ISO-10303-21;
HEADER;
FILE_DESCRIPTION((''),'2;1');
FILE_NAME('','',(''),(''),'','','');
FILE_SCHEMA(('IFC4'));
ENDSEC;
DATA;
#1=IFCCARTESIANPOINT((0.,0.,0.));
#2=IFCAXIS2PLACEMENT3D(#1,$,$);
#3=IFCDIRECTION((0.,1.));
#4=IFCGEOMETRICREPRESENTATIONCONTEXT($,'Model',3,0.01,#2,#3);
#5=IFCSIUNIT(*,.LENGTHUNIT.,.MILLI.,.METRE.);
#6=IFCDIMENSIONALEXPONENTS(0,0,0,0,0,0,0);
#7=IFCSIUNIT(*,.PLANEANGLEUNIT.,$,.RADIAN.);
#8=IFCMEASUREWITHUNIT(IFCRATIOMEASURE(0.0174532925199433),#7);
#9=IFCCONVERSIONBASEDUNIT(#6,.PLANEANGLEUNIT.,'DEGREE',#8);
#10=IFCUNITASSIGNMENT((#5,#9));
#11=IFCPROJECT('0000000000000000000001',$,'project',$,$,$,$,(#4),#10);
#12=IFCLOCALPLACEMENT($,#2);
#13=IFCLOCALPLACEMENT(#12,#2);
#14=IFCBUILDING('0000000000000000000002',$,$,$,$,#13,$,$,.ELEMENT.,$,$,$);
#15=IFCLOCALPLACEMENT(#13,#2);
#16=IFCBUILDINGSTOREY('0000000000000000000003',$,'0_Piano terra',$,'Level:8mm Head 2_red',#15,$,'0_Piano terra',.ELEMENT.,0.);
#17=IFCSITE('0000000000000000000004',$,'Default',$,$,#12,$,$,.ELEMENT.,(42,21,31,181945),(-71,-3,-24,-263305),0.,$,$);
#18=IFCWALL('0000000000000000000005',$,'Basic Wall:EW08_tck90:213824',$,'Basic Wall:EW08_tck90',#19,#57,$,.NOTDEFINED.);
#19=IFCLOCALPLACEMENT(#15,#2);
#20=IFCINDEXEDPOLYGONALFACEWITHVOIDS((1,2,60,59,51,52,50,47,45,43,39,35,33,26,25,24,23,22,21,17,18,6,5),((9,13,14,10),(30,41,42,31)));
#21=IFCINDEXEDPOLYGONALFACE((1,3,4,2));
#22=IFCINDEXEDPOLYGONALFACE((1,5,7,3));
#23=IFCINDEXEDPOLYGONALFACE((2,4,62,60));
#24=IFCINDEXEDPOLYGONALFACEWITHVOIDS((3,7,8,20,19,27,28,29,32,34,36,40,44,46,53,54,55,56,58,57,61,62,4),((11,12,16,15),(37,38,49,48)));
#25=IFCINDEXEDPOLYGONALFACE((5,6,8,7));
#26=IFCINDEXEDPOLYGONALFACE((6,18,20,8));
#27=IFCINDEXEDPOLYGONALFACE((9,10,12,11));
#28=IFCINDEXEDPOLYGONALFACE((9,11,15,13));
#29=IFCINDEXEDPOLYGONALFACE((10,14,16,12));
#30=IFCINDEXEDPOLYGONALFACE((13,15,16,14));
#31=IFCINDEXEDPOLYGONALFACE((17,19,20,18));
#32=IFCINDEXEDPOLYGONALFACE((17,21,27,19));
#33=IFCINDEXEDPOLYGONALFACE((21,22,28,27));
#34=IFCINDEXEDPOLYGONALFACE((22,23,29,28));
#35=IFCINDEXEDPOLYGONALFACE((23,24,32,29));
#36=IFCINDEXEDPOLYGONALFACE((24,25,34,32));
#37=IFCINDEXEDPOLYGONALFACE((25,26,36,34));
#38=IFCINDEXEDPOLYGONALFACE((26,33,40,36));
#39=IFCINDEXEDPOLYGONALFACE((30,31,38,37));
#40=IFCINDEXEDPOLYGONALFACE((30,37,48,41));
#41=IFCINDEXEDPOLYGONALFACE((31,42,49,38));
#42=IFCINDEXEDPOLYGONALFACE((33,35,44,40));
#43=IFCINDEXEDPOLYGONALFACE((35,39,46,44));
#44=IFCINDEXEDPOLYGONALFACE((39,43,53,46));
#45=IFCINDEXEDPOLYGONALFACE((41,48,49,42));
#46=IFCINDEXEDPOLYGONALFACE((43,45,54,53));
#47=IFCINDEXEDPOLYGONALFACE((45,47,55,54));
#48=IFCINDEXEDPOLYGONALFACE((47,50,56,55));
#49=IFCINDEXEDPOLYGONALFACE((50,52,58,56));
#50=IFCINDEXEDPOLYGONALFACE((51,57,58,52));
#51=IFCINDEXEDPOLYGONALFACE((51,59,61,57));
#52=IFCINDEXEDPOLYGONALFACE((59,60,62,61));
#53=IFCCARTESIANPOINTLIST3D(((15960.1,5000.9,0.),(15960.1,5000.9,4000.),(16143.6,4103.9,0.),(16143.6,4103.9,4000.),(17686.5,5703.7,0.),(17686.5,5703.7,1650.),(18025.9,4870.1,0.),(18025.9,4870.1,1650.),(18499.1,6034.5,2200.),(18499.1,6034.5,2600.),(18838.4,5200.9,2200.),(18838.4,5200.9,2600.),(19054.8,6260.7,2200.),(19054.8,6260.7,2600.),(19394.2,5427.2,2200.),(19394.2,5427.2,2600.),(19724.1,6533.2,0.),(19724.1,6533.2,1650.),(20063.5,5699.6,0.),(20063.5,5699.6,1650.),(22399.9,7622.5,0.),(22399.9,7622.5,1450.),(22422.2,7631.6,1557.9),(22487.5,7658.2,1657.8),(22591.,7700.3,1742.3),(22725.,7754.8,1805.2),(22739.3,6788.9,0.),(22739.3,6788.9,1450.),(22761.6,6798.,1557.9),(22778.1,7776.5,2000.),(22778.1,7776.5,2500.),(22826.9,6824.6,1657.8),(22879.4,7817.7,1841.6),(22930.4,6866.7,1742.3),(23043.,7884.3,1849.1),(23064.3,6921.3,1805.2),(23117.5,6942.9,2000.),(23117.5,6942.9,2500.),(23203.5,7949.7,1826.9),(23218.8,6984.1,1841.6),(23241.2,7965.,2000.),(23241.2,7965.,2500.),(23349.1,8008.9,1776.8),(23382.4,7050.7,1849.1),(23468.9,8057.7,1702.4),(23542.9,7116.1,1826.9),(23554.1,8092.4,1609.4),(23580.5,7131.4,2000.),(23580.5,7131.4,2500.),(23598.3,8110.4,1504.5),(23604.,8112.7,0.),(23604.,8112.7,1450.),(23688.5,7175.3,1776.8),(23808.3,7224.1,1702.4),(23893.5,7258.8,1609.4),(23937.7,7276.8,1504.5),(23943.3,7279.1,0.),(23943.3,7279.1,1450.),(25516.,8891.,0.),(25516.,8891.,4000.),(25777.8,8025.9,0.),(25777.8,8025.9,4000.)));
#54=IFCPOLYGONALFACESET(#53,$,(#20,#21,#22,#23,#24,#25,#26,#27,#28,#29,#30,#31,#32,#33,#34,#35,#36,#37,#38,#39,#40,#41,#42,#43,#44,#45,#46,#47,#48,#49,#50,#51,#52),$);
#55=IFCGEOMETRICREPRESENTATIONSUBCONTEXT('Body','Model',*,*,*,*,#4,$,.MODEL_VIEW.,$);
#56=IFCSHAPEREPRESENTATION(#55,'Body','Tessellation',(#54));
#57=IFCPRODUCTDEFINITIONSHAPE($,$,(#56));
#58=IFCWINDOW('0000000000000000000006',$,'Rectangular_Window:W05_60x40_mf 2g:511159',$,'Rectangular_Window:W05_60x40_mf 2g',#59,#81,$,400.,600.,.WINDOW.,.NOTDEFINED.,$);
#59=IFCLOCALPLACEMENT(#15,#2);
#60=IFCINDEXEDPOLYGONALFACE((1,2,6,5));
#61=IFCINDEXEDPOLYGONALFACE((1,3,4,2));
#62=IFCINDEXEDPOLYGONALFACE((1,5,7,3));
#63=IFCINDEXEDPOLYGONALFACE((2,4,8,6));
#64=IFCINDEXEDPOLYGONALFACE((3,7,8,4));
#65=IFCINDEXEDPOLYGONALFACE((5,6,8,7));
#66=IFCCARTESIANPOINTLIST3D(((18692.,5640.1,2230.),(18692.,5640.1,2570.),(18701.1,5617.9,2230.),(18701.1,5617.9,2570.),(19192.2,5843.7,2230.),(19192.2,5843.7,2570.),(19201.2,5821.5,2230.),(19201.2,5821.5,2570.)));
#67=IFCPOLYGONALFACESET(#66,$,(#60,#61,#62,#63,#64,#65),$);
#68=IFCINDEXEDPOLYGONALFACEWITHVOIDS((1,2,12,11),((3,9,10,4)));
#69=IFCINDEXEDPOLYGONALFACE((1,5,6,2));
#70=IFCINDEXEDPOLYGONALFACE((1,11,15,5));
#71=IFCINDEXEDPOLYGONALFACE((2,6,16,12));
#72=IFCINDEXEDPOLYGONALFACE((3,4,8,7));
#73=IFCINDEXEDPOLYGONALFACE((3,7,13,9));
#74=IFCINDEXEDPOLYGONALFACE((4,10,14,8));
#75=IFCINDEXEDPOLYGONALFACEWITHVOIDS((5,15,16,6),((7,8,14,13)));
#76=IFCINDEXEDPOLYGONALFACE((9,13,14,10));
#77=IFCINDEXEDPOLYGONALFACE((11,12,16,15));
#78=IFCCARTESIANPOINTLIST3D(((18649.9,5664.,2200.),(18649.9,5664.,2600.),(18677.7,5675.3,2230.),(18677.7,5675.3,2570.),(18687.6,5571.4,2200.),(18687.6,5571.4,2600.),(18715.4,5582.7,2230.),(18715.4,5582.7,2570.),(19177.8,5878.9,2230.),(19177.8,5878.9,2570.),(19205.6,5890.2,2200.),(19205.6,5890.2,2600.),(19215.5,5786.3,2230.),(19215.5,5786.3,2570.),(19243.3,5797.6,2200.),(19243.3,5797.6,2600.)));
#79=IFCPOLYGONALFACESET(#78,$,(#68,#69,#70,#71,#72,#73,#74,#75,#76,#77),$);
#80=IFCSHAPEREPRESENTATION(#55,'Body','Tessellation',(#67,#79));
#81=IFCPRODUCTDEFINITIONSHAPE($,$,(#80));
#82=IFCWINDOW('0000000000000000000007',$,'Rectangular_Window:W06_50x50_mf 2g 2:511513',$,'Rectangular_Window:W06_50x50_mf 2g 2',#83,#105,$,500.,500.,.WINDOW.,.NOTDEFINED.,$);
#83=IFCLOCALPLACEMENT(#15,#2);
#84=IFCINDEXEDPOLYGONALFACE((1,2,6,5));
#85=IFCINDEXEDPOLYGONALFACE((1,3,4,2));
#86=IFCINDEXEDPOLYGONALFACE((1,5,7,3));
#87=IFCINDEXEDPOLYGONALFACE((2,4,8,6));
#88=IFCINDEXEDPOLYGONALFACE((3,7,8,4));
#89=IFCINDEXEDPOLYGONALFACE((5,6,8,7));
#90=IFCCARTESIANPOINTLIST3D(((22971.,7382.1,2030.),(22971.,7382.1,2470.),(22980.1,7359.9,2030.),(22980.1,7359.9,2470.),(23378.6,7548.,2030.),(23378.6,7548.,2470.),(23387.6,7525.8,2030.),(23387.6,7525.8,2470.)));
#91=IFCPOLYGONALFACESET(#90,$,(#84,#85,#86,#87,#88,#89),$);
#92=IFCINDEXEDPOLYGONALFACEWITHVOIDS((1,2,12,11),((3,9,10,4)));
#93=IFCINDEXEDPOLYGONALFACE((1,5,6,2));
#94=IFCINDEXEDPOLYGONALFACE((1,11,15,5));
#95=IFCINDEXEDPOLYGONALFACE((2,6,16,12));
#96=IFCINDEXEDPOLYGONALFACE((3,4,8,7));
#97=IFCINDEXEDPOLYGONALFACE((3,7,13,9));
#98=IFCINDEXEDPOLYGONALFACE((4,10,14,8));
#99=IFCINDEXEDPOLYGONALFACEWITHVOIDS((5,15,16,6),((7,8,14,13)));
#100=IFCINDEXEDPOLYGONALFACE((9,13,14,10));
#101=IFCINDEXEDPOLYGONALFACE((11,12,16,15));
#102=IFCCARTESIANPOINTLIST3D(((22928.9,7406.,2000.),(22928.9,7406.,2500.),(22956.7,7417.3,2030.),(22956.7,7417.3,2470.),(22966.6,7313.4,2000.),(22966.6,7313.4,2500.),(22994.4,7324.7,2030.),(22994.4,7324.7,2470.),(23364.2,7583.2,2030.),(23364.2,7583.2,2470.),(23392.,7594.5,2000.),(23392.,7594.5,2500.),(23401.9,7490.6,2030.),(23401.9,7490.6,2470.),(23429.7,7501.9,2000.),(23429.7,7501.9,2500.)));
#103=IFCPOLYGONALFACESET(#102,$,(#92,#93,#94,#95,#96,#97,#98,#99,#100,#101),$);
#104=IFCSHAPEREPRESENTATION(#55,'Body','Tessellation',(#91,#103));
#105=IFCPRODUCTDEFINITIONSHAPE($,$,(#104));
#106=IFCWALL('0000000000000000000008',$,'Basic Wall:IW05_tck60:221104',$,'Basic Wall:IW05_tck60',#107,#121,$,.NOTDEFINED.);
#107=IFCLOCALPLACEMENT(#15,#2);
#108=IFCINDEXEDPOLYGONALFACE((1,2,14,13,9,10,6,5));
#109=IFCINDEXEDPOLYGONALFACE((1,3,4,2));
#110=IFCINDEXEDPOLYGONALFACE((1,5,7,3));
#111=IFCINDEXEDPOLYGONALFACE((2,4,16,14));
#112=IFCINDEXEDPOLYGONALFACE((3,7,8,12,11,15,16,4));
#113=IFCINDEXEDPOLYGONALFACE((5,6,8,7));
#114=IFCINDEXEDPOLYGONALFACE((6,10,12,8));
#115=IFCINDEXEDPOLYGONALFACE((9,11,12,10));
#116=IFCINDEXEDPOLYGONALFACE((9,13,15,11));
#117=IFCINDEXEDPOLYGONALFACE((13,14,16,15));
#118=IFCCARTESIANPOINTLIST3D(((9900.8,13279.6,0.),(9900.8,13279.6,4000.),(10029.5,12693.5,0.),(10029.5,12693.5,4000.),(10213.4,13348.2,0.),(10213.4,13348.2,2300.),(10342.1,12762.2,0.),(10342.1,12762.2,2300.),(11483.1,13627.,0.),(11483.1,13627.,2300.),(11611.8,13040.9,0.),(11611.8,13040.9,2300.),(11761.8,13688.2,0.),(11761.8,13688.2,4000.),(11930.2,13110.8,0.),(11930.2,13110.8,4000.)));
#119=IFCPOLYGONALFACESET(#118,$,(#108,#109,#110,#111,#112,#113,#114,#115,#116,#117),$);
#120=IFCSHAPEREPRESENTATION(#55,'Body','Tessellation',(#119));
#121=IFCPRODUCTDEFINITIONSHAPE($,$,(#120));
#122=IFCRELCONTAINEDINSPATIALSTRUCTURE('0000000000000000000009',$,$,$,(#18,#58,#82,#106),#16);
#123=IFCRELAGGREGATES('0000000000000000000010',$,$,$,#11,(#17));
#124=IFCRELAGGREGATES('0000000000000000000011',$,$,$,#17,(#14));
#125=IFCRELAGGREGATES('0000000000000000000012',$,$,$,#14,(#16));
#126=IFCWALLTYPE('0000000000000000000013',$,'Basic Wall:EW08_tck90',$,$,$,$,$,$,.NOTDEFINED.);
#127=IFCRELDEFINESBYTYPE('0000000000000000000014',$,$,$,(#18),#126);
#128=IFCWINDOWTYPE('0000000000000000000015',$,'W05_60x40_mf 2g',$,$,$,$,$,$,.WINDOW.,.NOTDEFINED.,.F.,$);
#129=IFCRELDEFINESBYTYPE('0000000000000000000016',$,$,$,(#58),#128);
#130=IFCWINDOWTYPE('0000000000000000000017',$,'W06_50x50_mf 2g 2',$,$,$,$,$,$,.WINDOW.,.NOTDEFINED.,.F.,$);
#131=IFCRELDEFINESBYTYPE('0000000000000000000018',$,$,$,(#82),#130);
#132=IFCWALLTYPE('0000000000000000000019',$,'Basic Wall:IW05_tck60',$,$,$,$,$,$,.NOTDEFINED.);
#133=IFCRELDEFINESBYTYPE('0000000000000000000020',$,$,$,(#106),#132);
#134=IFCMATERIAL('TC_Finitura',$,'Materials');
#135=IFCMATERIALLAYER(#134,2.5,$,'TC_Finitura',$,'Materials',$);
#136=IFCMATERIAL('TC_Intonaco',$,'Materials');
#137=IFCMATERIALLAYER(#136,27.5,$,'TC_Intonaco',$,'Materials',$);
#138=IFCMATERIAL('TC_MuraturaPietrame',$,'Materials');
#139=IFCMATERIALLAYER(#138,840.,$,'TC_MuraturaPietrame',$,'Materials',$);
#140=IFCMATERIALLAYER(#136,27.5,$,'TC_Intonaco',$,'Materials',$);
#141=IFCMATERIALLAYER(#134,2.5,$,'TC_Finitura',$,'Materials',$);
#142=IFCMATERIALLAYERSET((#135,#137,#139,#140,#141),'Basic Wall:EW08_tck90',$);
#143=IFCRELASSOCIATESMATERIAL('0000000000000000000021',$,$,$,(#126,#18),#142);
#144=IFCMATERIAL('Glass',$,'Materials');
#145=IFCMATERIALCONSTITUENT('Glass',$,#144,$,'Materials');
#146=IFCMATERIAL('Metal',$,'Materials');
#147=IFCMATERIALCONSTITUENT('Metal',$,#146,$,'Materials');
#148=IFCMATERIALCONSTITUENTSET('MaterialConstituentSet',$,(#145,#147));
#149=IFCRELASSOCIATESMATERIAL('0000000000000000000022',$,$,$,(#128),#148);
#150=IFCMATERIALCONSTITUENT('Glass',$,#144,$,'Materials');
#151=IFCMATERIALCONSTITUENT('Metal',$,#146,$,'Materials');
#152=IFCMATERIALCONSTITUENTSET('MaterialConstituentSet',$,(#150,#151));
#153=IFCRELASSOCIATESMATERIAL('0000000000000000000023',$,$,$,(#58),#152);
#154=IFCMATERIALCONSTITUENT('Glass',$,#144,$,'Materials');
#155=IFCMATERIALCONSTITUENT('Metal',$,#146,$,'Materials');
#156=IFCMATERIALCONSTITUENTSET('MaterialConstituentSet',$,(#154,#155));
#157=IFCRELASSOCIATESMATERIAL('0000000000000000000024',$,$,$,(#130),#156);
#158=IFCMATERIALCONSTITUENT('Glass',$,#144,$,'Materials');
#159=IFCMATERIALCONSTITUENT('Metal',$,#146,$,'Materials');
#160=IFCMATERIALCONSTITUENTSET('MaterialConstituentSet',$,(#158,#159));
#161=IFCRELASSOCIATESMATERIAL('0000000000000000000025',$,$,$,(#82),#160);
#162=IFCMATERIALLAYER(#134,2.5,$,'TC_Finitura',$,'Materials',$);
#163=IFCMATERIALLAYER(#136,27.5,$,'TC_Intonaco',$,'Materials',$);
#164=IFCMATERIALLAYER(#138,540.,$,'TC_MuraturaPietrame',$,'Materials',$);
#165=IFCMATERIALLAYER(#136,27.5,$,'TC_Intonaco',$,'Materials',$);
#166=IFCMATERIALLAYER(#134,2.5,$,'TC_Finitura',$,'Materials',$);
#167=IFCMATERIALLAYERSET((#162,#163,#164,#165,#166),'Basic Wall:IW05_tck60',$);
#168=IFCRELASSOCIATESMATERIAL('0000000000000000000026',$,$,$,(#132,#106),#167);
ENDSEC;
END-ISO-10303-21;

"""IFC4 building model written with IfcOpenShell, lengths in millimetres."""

from ifc_helpers import new_model, entity, si_unit, converted_unit, direction, frame, frame_2d, origin, origin_2d_with_axis, place, context, subcontext, project, spatial, polyline, rectangle, outline, extrude, clip, halfspace, bounded_halfspace, source, transform, mapped, material, layer, layer_set, layer_usage, constituent, constituent_set, type_object, type_shapes, element, fill, save


model = new_model("IFC4")

# Units and contexts
model_context = context("Model", 3, precision=0.01, world=origin(), true_north=direction((0.0, 1.0)))
body_context = subcontext(model_context, "Body", "Model", "MODEL_VIEW")
ifc_project = project(units=[si_unit("LENGTHUNIT", "METRE", prefix="MILLI"), converted_unit("PLANEANGLEUNIT", "DEGREE", entity("IfcRatioMeasure", 0.0174532925199433), si_unit("PLANEANGLEUNIT", "RADIAN"), dimensions=[0, 0, 0, 0, 0, 0, 0])], contexts=[model_context])

# Site, building, storey
site_placement = place(None, origin())
site = spatial("IfcSite", under=ifc_project, at=site_placement, Name="Default", CompositionType="ELEMENT", RefLatitude=(42, 21, 31, 181945), RefLongitude=(-71, -3, -24, -263305), RefElevation=0.0)
building_placement = place(site_placement, origin())
building = spatial("IfcBuilding", under=site, at=building_placement, CompositionType="ELEMENT")
storey_placement = place(building_placement, origin())
storey = spatial("IfcBuildingStorey", under=building, at=storey_placement, Name="0_Piano terra", ObjectType="Level:8mm Head 2_red", LongName="0_Piano terra", CompositionType="ELEMENT", Elevation=0.0)

# Shared definitions
ifc_material_1 = material(Name="TC_Finitura", Category="Materials")
ifc_material_2 = material(Name="TC_Intonaco", Category="Materials")
ifc_material_3 = material(Name="TC_MuraturaPietrame", Category="Materials")

# Wall, openings, windows
ifc_layer_1 = layer(ifc_material_1, 2.5, Name="TC_Finitura", Category="Materials")
ifc_layer_2 = layer(ifc_material_2, 27.5, Name="TC_Intonaco", Category="Materials")
ifc_layer_3 = layer(ifc_material_3, 840.0, Name="TC_MuraturaPietrame", Category="Materials")
ifc_layer_4 = layer(ifc_material_2, 27.5, Name="TC_Intonaco", Category="Materials")
ifc_layer_5 = layer(ifc_material_1, 2.5, Name="TC_Finitura", Category="Materials")
ifc_layer_set_1 = layer_set([ifc_layer_1, ifc_layer_2, ifc_layer_3, ifc_layer_4, ifc_layer_5], Name="Basic Wall:EW08_tck90")
ifc_layer_usage_1 = layer_usage(ifc_layer_set_1, "AXIS2", "NEGATIVE", 450.0)
wall_type_1 = type_object("IfcWallType", Name="Basic Wall:EW08_tck90", PredefinedType="NOTDEFINED", material=ifc_layer_set_1)
wall_1_placement = place(storey_placement, frame((15973.9, 4520.6, 0.0), z_axis=(0.0, 0.0, 1.0), x_axis=(0.926193, 0.37705, 0.0)))
wall_1 = element("IfcWall", 1, at=wall_1_placement, inside=storey, type_object=wall_type_1, material=ifc_layer_usage_1, Name="Basic Wall:EW08_tck90:213824", ObjectType="Basic Wall:EW08_tck90", PredefinedType="NOTDEFINED", context=body_context, shape_type="Clipping", body=[
    clip(clip(extrude(outline(polyline([(0.0, -450.0), (10402.0, -450.0), (10485.6, 450.0), (9832.8, 450.0), (5558.3, 450.0), (4752.1, 450.0), (982.2, 450.0), (168.3, 450.0), (147.4, 338.3), (0.0, -450.0)])), origin(), (0.0, 0.0, 1.0), 4000.0), bounded_halfspace(frame((0.0, -450.0, 4000.0), z_axis=(0.0, 0.0, -1.0), x_axis=(-0.107776, -0.994175, 0.0)), True, frame((0.0, -450.0, 4000.0)), polyline([(0.0, 0.0), (10402.0, 0.0), (10485.6, 900.0), (9832.8, 900.0), (5558.3, 900.0), (4752.1, 900.0), (982.2, 900.0), (168.3, 900.0), (147.4, 788.3), (0.0, 0.0)]))), halfspace(frame((0.0, 0.0, -550.0)), True)),
])
opening_1_placement = place(wall_1_placement, frame((4612.0, 946.6, -550.0)))
element("IfcOpeningElement", 2, at=opening_1_placement, cuts=wall_1, ObjectType="Recess", PredefinedType="OPENING", context=body_context, shape_type="SweptSolid", body=[
    extrude(rectangle(XDim=2100.0, YDim=800.0, at=frame_2d((0.0, 0.0), x_axis=(0.0, 1.0))), frame((589.2, -127.8, 1050.0), z_axis=(0.12383, 0.992303, 0.0), x_axis=(0.992303, -0.12383, 0.0)), (0.0, 0.0, 1.0), 800.0),
])
opening_2_placement = place(wall_1_placement, frame((6054.8, -641.6, -550.0), z_axis=(0.0, 0.0, 1.0), x_axis=(0.926193, -0.37705, 0.0)))
element("IfcOpeningElement", 3, at=opening_2_placement, cuts=wall_1, ObjectType="Opening", PredefinedType="OPENING", context=body_context, shape_type="SweptSolid", body=[
    extrude(outline(polyline([(-1928.3, -671.7), (71.7, -671.7), (179.7, -647.6), (279.6, -577.0), (364.1, -465.3), (426.9, -320.7), (463.4, -153.9), (470.8, 22.7), (448.6, 196.0), (398.5, 353.2), (324.2, 482.5), (231.1, 574.5), (126.2, 622.3), (71.7, 628.3), (-1928.3, 628.3), (-1928.3, -671.7)])), frame((1772.9, 254.8, 1928.3), z_axis=(-0.37705, 0.926193, 0.0), x_axis=(0.0, 0.0, 1.0)), (0.0, 0.0, 1.0), 3048.0),
])
opening_3_placement = place(wall_1_placement, frame((967.8, -640.7, -550.0), z_axis=(0.0, 0.0, 1.0), x_axis=(0.926193, -0.37705, 0.0)))
element("IfcOpeningElement", 4, at=opening_3_placement, cuts=wall_1, ObjectType="Opening", PredefinedType="OPENING", context=body_context, shape_type="SweptSolid", body=[
    extrude(rectangle(XDim=2200.0, YDim=2200.0, at=origin_2d_with_axis()), frame((2168.1, 414.8, 1100.0), z_axis=(-0.37705, 0.926193, 0.0), x_axis=(0.0, 0.0, 1.0)), (0.0, 0.0, 1.0), 3048.0),
])
opening_4_placement = place(wall_1_placement, frame((7529.6, -450.0, 2000.0)))
opening_4 = element("IfcOpeningElement", 5, at=opening_4_placement, cuts=wall_1, ObjectType="Opening", PredefinedType="OPENING", context=body_context, shape_type="SweptSolid", body=[
    extrude(rectangle(XDim=500.0, YDim=500.0, at=frame_2d((250.0, 250.0), x_axis=(-1.0, 0.0))), frame((0.0, 0.0, 0.0), z_axis=(0.0, 1.0, 0.0), x_axis=(0.0, 0.0, 1.0)), (0.0, 0.0, 1.0), 900.0),
])
opening_5_placement = place(wall_1_placement, frame((2909.6, -450.0, 2200.0)))
opening_5 = element("IfcOpeningElement", 6, at=opening_5_placement, cuts=wall_1, ObjectType="Opening", PredefinedType="OPENING", context=body_context, shape_type="SweptSolid", body=[
    extrude(rectangle(XDim=400.0, YDim=600.0, at=frame_2d((200.0, 300.0), x_axis=(-1.0, 0.0))), frame((0.0, 0.0, 0.0), z_axis=(0.0, 1.0, 0.0), x_axis=(0.0, 0.0, 1.0)), (0.0, 0.0, 1.0), 900.0),
])
ifc_material_4 = material(Name="Glass", Category="Materials")
ifc_constituent_1 = constituent(ifc_material_4, Name="Glass", Category="Materials")
ifc_material_5 = material(Name="Metal", Category="Materials")
ifc_constituent_2 = constituent(ifc_material_5, Name="Metal", Category="Materials")
ifc_constituent_set_1 = constituent_set(constituents=[ifc_constituent_1, ifc_constituent_2], Name="MaterialConstituentSet")
ifc_constituent_3 = constituent(ifc_material_4, Name="Glass", Category="Materials")
ifc_constituent_4 = constituent(ifc_material_5, Name="Metal", Category="Materials")
ifc_constituent_set_2 = constituent_set(constituents=[ifc_constituent_3, ifc_constituent_4], Name="MaterialConstituentSet")
window_type_1 = type_object("IfcWindowType", Name="W05_60x40_mf 2g", ParameterTakesPrecedence=False, PartitioningType="NOTDEFINED", PredefinedType="WINDOW", material=ifc_constituent_set_2)
shared_shape_1 = source(origin(), body_context, "Body", "SweptSolid", [
    extrude(rectangle(XDim=24.0, YDim=540.0, at=origin_2d_with_axis()), frame((300.0, 450.0, 30.0), z_axis=(0.0, 0.0, 1.0), x_axis=(0.0, 1.0, 0.0)), (0.0, 0.0, 1.0), 340.0),
    extrude(outline(polyline([(-300.0, -200.0), (300.0, -200.0), (300.0, 200.0), (-300.0, 200.0), (-300.0, -200.0)]), holes=[polyline([(-270.0, -170.0), (-270.0, 170.0), (270.0, 170.0), (270.0, -170.0), (-270.0, -170.0)])]), frame((300.0, 400.0, 200.0), z_axis=(0.0, 1.0, 0.0), x_axis=(1.0, 0.0, 0.0)), (0.0, 0.0, 1.0), 100.0),
])
type_shapes(window_type_1, [shared_shape_1])
window_1_placement = place(opening_5_placement, origin())
window_1 = element("IfcWindow", 7, at=window_1_placement, inside=storey, type_object=window_type_1, material=ifc_constituent_set_1, Name="Rectangular_Window:W05_60x40_mf 2g:511159", ObjectType="Rectangular_Window:W05_60x40_mf 2g", OverallHeight=400.0, OverallWidth=600.0, PartitioningType="NOTDEFINED", PredefinedType="WINDOW", context=body_context, shape_type="MappedRepresentation", body=[
    mapped(shared_shape_1, transform((0.0, 0.0, 0.0), scale=1.0)),
])
fill(opening_5, window_1)
ifc_constituent_5 = constituent(ifc_material_4, Name="Glass", Category="Materials")
ifc_constituent_6 = constituent(ifc_material_5, Name="Metal", Category="Materials")
ifc_constituent_set_3 = constituent_set(constituents=[ifc_constituent_5, ifc_constituent_6], Name="MaterialConstituentSet")
ifc_constituent_7 = constituent(ifc_material_4, Name="Glass", Category="Materials")
ifc_constituent_8 = constituent(ifc_material_5, Name="Metal", Category="Materials")
ifc_constituent_set_4 = constituent_set(constituents=[ifc_constituent_7, ifc_constituent_8], Name="MaterialConstituentSet")
window_type_2 = type_object("IfcWindowType", Name="W06_50x50_mf 2g 2", ParameterTakesPrecedence=False, PartitioningType="NOTDEFINED", PredefinedType="WINDOW", material=ifc_constituent_set_4)
shared_shape_2 = source(origin(), body_context, "Body", "SweptSolid", [
    extrude(rectangle(XDim=24.0, YDim=440.0, at=origin_2d_with_axis()), frame((250.0, 450.0, 30.0), z_axis=(0.0, 0.0, 1.0), x_axis=(0.0, 1.0, 0.0)), (0.0, 0.0, 1.0), 440.0),
    extrude(outline(polyline([(-250.0, -250.0), (250.0, -250.0), (250.0, 250.0), (-250.0, 250.0), (-250.0, -250.0)]), holes=[polyline([(-220.0, -220.0), (-220.0, 220.0), (220.0, 220.0), (220.0, -220.0), (-220.0, -220.0)])]), frame((250.0, 400.0, 250.0), z_axis=(0.0, 1.0, 0.0), x_axis=(1.0, 0.0, 0.0)), (0.0, 0.0, 1.0), 100.0),
])
type_shapes(window_type_2, [shared_shape_2])
window_2_placement = place(opening_4_placement, origin())
window_2 = element("IfcWindow", 8, at=window_2_placement, inside=storey, type_object=window_type_2, material=ifc_constituent_set_3, Name="Rectangular_Window:W06_50x50_mf 2g 2:511513", ObjectType="Rectangular_Window:W06_50x50_mf 2g 2", OverallHeight=500.0, OverallWidth=500.0, PartitioningType="NOTDEFINED", PredefinedType="WINDOW", context=body_context, shape_type="MappedRepresentation", body=[
    mapped(shared_shape_2, transform((0.0, 0.0, 0.0), scale=1.0)),
])
fill(opening_4, window_2)

# Shared definitions
ifc_layer_6 = layer(ifc_material_1, 2.5, Name="TC_Finitura", Category="Materials")
ifc_layer_7 = layer(ifc_material_2, 27.5, Name="TC_Intonaco", Category="Materials")
ifc_layer_8 = layer(ifc_material_3, 540.0, Name="TC_MuraturaPietrame", Category="Materials")
ifc_layer_9 = layer(ifc_material_2, 27.5, Name="TC_Intonaco", Category="Materials")
ifc_layer_10 = layer(ifc_material_1, 2.5, Name="TC_Finitura", Category="Materials")
ifc_layer_set_2 = layer_set([ifc_layer_6, ifc_layer_7, ifc_layer_8, ifc_layer_9, ifc_layer_10], Name="Basic Wall:IW05_tck60")
wall_type_2 = type_object("IfcWallType", Name="Basic Wall:IW05_tck60", PredefinedType="NOTDEFINED", material=ifc_layer_set_2)

# Wall, opening
ifc_layer_usage_2 = layer_usage(ifc_layer_set_2, "AXIS2", "NEGATIVE", 300.0)
wall_2_placement = place(storey_placement, frame((11865.8, 13403.9, 0.0), z_axis=(0.0, 0.0, 1.0), x_axis=(-0.976736, -0.214446, 0.0)))
wall_2 = element("IfcWall", 9, at=wall_2_placement, inside=storey, type_object=wall_type_2, material=ifc_layer_usage_2, Name="Basic Wall:IW05_tck60:221104", ObjectType="Basic Wall:IW05_tck60", PredefinedType="NOTDEFINED", context=body_context, shape_type="Clipping", body=[
    clip(extrude(outline(polyline([(40.6, -300.0), (1945.9, -300.0), (1945.9, 300.0), (0.0, 300.0), (40.6, -300.0)])), origin(), (0.0, 0.0, 1.0), 4000.0), bounded_halfspace(frame((40.6, -300.0, 4000.0), z_axis=(0.0, 0.0, -1.0), x_axis=(-0.062458, 0.998048, 0.0)), True, frame((40.6, -300.0, 4000.0)), polyline([(0.0, 0.0), (1905.3, 0.0), (1905.3, 600.0), (-40.6, 600.0), (0.0, 0.0)]))),
])
opening_6_placement = place(wall_2_placement, frame((1751.6, 272.4, 0.0)))
element("IfcOpeningElement", 10, at=opening_6_placement, cuts=wall_2, ObjectType="Opening", PredefinedType="OPENING", context=body_context, shape_type="SweptSolid", body=[
    extrude(rectangle(XDim=2300.0, YDim=1300.0, at=frame_2d((0.0, 0.0), x_axis=(1.0, 0.0))), frame((-775.7, -572.4, 1150.0), z_axis=(0.0, 1.0, 0.0), x_axis=(0.0, 0.0, -1.0)), (0.0, 0.0, 1.0), 600.0),
])

save(model, "model.ifc")
